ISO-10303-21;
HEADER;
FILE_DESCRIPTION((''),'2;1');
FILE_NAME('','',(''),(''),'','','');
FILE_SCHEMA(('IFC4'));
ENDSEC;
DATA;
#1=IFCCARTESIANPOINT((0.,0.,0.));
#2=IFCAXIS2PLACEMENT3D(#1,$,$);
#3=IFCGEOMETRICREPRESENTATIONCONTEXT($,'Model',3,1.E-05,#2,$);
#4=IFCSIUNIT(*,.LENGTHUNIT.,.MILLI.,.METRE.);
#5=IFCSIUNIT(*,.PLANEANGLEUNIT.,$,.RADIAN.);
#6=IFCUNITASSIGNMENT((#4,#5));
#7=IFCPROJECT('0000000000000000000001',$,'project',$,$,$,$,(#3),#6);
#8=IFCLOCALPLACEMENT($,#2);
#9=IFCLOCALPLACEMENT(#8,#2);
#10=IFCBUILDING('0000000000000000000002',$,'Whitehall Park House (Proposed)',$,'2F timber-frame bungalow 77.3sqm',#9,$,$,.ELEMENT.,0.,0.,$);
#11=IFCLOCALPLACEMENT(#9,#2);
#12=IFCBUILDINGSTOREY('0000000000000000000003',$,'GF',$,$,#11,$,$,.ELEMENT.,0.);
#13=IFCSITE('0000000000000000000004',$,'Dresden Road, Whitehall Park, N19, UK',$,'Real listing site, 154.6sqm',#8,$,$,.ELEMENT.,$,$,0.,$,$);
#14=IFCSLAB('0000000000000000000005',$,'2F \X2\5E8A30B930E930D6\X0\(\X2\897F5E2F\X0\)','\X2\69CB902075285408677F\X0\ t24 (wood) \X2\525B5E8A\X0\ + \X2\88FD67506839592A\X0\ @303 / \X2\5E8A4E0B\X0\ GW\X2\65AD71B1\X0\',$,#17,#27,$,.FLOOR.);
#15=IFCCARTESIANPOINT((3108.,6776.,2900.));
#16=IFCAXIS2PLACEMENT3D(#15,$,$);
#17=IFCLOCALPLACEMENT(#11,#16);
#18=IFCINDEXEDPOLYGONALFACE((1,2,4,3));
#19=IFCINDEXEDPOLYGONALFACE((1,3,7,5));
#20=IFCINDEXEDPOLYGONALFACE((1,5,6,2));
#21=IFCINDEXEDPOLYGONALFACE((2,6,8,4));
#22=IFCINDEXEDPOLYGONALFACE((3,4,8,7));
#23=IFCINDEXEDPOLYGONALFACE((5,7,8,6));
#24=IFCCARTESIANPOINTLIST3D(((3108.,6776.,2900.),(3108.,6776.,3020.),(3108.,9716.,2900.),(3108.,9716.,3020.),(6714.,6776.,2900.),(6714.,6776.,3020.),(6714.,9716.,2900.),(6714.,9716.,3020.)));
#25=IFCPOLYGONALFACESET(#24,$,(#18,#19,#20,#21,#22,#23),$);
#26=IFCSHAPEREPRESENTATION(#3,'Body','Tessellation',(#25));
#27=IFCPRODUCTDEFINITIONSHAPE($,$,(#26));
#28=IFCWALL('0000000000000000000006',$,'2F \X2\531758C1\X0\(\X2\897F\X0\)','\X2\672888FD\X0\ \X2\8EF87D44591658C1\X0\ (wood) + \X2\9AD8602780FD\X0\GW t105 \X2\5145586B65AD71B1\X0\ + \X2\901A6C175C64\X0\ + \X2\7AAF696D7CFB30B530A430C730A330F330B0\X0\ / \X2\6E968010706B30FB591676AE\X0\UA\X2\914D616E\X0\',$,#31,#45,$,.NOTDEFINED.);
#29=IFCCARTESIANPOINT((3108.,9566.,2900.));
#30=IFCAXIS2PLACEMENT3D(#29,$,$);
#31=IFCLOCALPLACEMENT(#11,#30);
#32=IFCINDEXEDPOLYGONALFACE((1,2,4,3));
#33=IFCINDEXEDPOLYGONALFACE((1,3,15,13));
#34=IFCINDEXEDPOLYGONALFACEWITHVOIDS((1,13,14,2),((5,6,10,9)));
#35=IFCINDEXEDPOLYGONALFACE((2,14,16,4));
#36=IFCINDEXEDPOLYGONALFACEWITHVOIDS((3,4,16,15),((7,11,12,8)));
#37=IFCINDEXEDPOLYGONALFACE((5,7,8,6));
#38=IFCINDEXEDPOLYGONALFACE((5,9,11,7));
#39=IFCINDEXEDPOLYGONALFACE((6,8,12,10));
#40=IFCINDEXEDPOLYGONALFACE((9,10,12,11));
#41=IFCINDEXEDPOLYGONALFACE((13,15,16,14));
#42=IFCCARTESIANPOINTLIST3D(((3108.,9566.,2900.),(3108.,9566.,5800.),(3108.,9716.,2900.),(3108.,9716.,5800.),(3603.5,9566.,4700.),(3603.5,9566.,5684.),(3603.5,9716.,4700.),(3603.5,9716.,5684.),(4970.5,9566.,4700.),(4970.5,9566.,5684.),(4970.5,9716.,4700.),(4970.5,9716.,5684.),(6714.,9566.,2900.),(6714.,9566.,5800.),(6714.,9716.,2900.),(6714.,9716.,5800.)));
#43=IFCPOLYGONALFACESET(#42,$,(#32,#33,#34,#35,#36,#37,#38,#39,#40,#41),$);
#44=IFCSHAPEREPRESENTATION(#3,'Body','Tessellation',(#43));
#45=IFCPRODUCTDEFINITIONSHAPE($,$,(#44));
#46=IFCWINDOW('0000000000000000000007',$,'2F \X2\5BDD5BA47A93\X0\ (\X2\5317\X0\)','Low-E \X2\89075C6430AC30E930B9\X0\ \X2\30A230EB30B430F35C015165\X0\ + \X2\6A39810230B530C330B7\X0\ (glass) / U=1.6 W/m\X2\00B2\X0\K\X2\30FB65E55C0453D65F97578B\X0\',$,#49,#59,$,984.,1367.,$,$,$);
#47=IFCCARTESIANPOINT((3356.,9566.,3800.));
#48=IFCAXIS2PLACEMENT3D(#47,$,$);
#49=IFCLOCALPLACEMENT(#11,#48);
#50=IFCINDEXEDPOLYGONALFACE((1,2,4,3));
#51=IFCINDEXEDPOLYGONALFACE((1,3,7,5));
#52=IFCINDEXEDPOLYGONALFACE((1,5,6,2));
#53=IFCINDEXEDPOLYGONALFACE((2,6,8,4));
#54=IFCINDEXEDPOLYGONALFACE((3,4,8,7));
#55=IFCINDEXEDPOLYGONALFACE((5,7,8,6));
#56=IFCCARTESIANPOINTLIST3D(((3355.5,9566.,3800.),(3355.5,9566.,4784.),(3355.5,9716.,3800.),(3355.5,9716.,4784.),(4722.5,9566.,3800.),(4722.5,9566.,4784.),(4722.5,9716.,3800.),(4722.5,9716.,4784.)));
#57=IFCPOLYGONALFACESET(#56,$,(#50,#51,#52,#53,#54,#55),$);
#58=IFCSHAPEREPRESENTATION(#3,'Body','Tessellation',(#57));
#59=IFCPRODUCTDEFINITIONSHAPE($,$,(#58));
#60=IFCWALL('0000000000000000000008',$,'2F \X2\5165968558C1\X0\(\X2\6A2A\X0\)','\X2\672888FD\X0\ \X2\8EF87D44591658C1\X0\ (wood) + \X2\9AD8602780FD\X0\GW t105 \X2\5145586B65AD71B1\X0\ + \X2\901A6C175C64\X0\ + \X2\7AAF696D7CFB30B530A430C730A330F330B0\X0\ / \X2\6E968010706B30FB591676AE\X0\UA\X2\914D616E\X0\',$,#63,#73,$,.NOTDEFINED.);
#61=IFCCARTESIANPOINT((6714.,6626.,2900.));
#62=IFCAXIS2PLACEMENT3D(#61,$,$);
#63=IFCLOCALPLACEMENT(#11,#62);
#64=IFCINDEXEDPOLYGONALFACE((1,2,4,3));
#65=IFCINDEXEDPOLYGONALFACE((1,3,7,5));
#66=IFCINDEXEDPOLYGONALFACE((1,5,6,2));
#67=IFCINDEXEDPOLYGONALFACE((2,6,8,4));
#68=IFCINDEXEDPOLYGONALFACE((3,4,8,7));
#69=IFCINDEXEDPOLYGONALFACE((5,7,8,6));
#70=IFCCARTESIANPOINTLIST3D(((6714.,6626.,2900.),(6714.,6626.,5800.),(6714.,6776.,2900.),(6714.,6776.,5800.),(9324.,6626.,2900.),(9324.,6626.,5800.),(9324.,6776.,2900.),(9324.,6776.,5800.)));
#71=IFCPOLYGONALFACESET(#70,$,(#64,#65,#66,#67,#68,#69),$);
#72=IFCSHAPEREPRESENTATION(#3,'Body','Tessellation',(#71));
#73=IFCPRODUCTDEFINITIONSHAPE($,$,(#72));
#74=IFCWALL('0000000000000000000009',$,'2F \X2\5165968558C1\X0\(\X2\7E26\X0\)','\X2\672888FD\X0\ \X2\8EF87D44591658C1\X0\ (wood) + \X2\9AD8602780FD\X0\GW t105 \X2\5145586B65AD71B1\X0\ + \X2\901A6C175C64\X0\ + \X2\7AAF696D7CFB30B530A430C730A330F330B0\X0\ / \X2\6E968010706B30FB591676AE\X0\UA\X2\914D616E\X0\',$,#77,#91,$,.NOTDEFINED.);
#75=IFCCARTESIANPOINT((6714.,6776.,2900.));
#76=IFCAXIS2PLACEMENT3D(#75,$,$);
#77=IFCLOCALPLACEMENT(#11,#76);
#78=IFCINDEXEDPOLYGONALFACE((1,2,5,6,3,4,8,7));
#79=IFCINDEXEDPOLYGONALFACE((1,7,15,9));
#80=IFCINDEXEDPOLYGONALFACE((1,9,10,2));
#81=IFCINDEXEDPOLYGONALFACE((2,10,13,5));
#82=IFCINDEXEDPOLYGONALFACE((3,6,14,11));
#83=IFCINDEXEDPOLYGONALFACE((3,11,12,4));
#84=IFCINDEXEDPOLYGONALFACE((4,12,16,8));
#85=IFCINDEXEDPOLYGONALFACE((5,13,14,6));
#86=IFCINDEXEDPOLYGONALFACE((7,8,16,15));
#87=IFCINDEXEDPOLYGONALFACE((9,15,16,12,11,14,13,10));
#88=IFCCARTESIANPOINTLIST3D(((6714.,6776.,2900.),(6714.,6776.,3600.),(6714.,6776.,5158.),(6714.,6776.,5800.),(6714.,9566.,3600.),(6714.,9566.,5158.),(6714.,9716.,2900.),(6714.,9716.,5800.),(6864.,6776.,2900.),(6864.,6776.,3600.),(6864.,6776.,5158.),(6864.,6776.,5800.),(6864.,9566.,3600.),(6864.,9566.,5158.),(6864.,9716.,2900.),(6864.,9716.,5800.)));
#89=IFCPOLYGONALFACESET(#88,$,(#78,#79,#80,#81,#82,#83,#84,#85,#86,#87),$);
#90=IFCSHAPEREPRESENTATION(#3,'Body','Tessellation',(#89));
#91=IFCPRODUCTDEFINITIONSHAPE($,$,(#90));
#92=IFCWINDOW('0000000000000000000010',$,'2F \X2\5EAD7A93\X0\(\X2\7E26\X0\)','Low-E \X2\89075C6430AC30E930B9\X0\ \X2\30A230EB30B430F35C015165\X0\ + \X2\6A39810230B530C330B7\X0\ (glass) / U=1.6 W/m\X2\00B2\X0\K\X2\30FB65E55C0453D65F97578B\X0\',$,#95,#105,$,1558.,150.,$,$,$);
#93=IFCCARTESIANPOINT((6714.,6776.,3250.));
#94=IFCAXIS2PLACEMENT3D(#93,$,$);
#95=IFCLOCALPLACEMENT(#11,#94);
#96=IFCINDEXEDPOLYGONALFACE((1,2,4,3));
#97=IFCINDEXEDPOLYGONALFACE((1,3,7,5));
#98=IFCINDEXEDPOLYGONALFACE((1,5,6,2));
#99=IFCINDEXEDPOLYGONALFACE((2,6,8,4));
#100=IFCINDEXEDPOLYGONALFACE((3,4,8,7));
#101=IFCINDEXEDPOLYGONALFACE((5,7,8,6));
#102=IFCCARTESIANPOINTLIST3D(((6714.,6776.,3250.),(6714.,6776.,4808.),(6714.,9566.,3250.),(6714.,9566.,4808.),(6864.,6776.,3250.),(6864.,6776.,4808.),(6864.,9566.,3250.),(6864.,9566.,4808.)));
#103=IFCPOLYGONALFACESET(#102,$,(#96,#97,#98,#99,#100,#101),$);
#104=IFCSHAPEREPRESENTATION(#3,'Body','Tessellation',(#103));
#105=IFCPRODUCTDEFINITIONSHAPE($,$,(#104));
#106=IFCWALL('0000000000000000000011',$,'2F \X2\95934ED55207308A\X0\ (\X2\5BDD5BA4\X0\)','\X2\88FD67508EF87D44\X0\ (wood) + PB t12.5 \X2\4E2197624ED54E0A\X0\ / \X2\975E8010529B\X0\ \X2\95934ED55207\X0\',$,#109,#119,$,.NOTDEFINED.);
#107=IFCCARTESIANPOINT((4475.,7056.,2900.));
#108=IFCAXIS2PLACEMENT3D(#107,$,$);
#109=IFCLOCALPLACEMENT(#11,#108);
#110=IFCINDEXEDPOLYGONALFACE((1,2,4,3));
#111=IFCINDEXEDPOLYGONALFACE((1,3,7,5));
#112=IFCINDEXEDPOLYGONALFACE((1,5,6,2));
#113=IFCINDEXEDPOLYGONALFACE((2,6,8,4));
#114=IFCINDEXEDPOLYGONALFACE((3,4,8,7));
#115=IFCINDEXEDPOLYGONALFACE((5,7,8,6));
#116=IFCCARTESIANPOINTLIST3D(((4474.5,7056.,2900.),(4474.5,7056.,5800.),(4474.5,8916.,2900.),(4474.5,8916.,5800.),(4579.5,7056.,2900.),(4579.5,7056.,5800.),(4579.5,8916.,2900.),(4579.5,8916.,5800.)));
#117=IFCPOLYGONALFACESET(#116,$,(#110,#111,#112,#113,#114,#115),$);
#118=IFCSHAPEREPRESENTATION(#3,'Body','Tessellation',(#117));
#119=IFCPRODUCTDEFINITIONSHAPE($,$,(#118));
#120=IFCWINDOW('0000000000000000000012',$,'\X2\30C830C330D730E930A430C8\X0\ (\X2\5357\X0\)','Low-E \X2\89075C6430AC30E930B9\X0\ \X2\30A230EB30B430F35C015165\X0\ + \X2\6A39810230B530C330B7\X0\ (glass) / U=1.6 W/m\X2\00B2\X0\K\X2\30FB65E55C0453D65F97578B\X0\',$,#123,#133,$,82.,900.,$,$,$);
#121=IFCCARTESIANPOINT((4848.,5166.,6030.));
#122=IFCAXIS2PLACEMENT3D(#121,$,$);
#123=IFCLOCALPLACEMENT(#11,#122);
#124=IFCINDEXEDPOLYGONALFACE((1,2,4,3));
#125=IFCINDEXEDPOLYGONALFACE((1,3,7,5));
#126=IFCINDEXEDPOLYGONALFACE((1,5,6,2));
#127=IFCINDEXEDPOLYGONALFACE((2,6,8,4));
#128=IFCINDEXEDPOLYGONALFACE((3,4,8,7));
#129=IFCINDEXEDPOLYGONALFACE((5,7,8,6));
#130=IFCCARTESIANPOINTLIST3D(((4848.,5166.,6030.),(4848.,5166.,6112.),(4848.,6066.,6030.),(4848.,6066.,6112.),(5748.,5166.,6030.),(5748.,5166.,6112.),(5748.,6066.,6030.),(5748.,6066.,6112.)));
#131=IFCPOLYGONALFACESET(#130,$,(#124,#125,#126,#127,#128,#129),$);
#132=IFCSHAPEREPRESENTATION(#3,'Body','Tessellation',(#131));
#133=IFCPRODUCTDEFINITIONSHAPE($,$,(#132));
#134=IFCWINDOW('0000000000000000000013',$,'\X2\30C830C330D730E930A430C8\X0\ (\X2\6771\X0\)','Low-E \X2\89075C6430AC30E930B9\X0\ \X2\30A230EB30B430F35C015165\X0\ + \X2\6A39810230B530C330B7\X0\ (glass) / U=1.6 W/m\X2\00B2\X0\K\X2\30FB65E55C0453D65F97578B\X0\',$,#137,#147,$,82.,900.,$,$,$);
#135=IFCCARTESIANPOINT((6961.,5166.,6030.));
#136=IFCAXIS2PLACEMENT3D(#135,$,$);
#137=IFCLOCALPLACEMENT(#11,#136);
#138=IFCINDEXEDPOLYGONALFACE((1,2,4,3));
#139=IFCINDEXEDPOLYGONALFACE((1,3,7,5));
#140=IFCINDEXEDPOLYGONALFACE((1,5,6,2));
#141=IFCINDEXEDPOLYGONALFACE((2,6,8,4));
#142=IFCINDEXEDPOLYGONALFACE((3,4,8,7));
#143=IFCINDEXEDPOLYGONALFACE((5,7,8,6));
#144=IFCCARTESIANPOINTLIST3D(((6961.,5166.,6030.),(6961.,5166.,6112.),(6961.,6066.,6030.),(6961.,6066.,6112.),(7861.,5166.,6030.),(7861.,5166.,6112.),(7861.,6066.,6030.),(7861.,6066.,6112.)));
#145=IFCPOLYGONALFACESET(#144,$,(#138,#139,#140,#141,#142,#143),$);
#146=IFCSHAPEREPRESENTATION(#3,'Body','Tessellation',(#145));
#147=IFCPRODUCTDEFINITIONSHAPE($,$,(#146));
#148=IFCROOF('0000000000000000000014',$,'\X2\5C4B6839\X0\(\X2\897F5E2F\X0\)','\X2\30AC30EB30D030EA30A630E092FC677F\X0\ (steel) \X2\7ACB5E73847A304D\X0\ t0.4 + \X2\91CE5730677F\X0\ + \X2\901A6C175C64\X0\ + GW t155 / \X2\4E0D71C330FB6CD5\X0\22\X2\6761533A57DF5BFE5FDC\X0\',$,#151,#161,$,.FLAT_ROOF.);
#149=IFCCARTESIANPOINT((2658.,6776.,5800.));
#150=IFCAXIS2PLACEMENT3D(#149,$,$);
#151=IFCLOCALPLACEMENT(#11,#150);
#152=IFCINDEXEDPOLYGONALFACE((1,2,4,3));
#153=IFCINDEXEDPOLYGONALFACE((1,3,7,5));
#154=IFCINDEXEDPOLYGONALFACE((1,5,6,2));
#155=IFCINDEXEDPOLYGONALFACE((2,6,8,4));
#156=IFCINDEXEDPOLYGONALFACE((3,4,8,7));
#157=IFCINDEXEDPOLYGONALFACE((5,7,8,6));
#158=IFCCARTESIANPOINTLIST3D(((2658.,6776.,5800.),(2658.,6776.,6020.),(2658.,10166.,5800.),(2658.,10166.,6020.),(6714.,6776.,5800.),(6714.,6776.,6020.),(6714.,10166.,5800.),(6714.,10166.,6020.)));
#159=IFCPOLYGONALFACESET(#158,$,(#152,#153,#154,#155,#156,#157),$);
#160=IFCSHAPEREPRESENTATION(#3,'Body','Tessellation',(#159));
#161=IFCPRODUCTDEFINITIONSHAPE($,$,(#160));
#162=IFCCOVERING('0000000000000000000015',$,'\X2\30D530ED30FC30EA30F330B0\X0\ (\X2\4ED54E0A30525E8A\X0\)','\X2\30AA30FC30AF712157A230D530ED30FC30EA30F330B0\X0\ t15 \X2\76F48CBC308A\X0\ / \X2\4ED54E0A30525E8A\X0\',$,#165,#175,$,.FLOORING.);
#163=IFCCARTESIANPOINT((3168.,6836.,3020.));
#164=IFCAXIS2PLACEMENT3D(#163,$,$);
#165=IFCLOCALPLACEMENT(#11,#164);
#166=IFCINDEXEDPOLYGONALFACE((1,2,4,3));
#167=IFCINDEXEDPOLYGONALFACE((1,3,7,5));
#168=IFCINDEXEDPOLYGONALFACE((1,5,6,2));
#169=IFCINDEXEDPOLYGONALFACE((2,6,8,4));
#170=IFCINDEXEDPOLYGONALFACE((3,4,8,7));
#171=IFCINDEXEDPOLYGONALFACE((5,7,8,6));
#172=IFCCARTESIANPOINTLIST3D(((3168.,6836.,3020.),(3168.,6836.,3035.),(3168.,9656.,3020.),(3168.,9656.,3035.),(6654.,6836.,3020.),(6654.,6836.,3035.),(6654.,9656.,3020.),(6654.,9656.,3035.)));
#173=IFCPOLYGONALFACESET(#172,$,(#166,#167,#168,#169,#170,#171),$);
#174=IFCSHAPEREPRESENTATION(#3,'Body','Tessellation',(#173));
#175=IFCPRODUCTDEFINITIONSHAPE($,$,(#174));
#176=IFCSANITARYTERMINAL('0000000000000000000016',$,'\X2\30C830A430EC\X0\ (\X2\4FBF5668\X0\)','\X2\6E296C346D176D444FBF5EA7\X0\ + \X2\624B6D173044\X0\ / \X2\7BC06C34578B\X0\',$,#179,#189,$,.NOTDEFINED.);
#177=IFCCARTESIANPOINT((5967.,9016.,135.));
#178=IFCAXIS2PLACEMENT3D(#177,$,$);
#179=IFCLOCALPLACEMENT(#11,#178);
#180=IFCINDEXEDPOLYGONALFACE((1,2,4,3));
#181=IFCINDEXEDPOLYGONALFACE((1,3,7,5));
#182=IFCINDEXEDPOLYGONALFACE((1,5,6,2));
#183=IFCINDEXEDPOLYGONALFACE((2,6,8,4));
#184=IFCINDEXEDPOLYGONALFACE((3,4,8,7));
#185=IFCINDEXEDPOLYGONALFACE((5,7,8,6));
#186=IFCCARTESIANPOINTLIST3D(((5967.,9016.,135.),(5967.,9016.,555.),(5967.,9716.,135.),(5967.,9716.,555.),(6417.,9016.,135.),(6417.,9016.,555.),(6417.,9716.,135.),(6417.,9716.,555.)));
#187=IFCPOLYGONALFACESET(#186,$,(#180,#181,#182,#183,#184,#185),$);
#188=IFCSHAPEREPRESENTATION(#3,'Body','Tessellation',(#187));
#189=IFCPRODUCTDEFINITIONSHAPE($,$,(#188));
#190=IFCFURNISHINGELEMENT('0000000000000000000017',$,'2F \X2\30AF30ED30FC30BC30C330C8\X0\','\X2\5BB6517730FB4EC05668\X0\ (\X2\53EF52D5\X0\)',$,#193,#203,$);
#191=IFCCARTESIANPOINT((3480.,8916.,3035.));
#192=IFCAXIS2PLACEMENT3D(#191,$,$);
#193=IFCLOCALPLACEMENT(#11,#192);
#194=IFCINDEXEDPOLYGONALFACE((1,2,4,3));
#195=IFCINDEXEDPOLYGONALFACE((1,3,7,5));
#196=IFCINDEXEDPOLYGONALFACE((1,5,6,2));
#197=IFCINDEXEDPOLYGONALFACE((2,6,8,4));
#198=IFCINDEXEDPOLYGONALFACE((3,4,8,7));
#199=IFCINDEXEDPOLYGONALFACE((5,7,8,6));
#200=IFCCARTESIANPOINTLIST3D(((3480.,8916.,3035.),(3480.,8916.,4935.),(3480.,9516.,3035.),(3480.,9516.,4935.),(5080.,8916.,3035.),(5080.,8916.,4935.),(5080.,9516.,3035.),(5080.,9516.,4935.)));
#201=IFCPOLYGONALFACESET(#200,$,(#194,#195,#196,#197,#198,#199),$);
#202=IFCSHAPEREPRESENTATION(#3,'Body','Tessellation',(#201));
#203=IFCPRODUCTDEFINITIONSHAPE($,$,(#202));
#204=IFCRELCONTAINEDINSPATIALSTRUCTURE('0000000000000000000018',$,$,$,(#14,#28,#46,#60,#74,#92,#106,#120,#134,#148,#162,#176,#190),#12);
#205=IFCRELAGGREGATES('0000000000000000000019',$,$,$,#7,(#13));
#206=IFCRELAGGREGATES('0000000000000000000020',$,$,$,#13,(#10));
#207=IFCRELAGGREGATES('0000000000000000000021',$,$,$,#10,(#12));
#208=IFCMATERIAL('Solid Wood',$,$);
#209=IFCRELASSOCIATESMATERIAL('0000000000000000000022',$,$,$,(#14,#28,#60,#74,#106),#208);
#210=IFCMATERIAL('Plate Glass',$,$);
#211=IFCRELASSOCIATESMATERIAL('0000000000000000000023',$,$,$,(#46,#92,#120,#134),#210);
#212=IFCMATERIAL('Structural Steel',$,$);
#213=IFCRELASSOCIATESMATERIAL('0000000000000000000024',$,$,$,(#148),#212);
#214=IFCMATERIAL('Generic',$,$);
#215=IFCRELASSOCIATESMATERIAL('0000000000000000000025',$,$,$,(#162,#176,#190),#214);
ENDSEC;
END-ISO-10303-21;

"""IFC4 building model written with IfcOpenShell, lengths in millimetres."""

from ifc_helpers import new_model, si_unit, frame, frame_2d, origin, place, context, project, spatial, rectangle, extrude, material, element, fill, save


model = new_model("IFC4")

# Units and contexts
model_context = context("Model", 3, precision=1e-05, world=origin())
ifc_project = project(units=[si_unit("LENGTHUNIT", "METRE", prefix="MILLI"), si_unit("PLANEANGLEUNIT", "RADIAN")], contexts=[model_context])

# Site, building, storey
site_placement = place(None, origin())
site = spatial("IfcSite", under=ifc_project, at=site_placement, Name="Dresden Road, Whitehall Park, N19, UK", ObjectType="Real listing site, 154.6sqm", CompositionType="ELEMENT", RefElevation=0.0)
building_placement = place(site_placement, origin())
building = spatial("IfcBuilding", under=site, at=building_placement, Name="Whitehall Park House (Proposed)", ObjectType="2F timber-frame bungalow 77.3sqm", CompositionType="ELEMENT", ElevationOfRefHeight=0.0, ElevationOfTerrain=0.0)
storey_placement = place(building_placement, origin())
storey = spatial("IfcBuildingStorey", under=building, at=storey_placement, Name="GF", CompositionType="ELEMENT", Elevation=0.0)

# Slab
ifc_material_1 = material(Name="Solid Wood")
slab_placement = place(storey_placement, frame((3108.0, 6776.0, 2900.0)))
element("IfcSlab", 1, at=slab_placement, inside=storey, material=ifc_material_1, Name="2F 床スラブ(西帯)", Description="構造用合板 t24 (wood) 剛床 + 製材根太 @303 / 床下 GW断熱", PredefinedType="FLOOR", context=model_context, shape_type="SweptSolid", body=[
    extrude(rectangle(XDim=3606.0, YDim=2940.0, at=frame_2d((1803.0, 1470.0))), frame((3108.0, 6776.0, 2900.0)), (0.0, 0.0, 1.0), 120.0),
])

# Wall, opening, window
wall_1_placement = place(storey_placement, frame((3108.0, 9566.0, 2900.0)))
wall_1 = element("IfcWall", 2, at=wall_1_placement, inside=storey, material=ifc_material_1, Name="2F 北壁(西)", Description="木製 軸組外壁 (wood) + 高性能GW t105 充填断熱 + 通気層 + 窯業系サイディング / 準耐火・外皮UA配慮", PredefinedType="NOTDEFINED", context=model_context, shape_type="SweptSolid", body=[
    extrude(rectangle(XDim=3606.0, YDim=150.0, at=frame_2d((1803.0, 75.0))), frame((3108.0, 9566.0, 2900.0)), (0.0, 0.0, 1.0), 2900.0),
])
opening_1_placement = place(storey_placement, frame((3356.0, 9566.0, 3800.0)))
opening_1 = element("IfcOpeningElement", 3, at=opening_1_placement, cuts=wall_1, PredefinedType="NOTDEFINED", context=model_context, shape_type="SweptSolid", body=[
    extrude(rectangle(XDim=1367.0, YDim=150.0, at=frame_2d((683.0, 75.0))), frame((3356.0, 9566.0, 3800.0)), (0.0, 0.0, 1.0), 984.0),
])
ifc_material_2 = material(Name="Plate Glass")
window_1_placement = place(storey_placement, frame((3356.0, 9566.0, 3800.0)))
window_1 = element("IfcWindow", 4, at=window_1_placement, inside=storey, material=ifc_material_2, Name="2F 寝室窓 (北)", Description="Low-E 複層ガラス アルゴン封入 + 樹脂サッシ (glass) / U=1.6 W/m²K・日射取得型", OverallHeight=984.0, OverallWidth=1367.0, context=model_context, shape_type="SweptSolid", body=[
    extrude(rectangle(XDim=1367.0, YDim=150.0, at=frame_2d((683.0, 75.0))), frame((3356.0, 9566.0, 3800.0)), (0.0, 0.0, 1.0), 984.0),
])
fill(opening_1, window_1)

# Wall
wall_2_placement = place(storey_placement, frame((6714.0, 6626.0, 2900.0)))
element("IfcWall", 5, at=wall_2_placement, inside=storey, material=ifc_material_1, Name="2F 入隅壁(横)", Description="木製 軸組外壁 (wood) + 高性能GW t105 充填断熱 + 通気層 + 窯業系サイディング / 準耐火・外皮UA配慮", PredefinedType="NOTDEFINED", context=model_context, shape_type="SweptSolid", body=[
    extrude(rectangle(XDim=2610.0, YDim=150.0, at=frame_2d((1305.0, 75.0))), frame((6714.0, 6626.0, 2900.0)), (0.0, 0.0, 1.0), 2900.0),
])

# Wall, opening, window
wall_3_placement = place(storey_placement, frame((6714.0, 6776.0, 2900.0)))
wall_3 = element("IfcWall", 6, at=wall_3_placement, inside=storey, material=ifc_material_1, Name="2F 入隅壁(縦)", Description="木製 軸組外壁 (wood) + 高性能GW t105 充填断熱 + 通気層 + 窯業系サイディング / 準耐火・外皮UA配慮", PredefinedType="NOTDEFINED", context=model_context, shape_type="SweptSolid", body=[
    extrude(rectangle(XDim=150.0, YDim=2940.0, at=frame_2d((75.0, 1470.0))), frame((6714.0, 6776.0, 2900.0)), (0.0, 0.0, 1.0), 2900.0),
])
opening_2_placement = place(storey_placement, frame((6714.0, 6776.0, 3250.0)))
opening_2 = element("IfcOpeningElement", 7, at=opening_2_placement, cuts=wall_3, PredefinedType="NOTDEFINED", context=model_context, shape_type="SweptSolid", body=[
    extrude(rectangle(XDim=150.0, YDim=2790.0, at=frame_2d((75.0, 1395.0))), frame((6714.0, 6776.0, 3250.0)), (0.0, 0.0, 1.0), 1558.0),
])
window_2_placement = place(storey_placement, frame((6714.0, 6776.0, 3250.0)))
window_2 = element("IfcWindow", 8, at=window_2_placement, inside=storey, material=ifc_material_2, Name="2F 庭窓(縦)", Description="Low-E 複層ガラス アルゴン封入 + 樹脂サッシ (glass) / U=1.6 W/m²K・日射取得型", OverallHeight=1558.0, OverallWidth=150.0, context=model_context, shape_type="SweptSolid", body=[
    extrude(rectangle(XDim=150.0, YDim=2790.0, at=frame_2d((75.0, 1395.0))), frame((6714.0, 6776.0, 3250.0)), (0.0, 0.0, 1.0), 1558.0),
])
fill(opening_2, window_2)

# Wall
wall_4_placement = place(storey_placement, frame((4475.0, 7056.0, 2900.0)))
element("IfcWall", 9, at=wall_4_placement, inside=storey, material=ifc_material_1, Name="2F 間仕切り (寝室)", Description="製材軸組 (wood) + PB t12.5 両面仕上 / 非耐力 間仕切", PredefinedType="NOTDEFINED", context=model_context, shape_type="SweptSolid", body=[
    extrude(rectangle(XDim=105.0, YDim=1860.0, at=frame_2d((52.0, 930.0))), frame((4475.0, 7056.0, 2900.0)), (0.0, 0.0, 1.0), 2900.0),
])

# Windows
window_3_placement = place(storey_placement, frame((4848.0, 5166.0, 6030.0)))
element("IfcWindow", 10, at=window_3_placement, inside=storey, material=ifc_material_2, Name="トップライト (南)", Description="Low-E 複層ガラス アルゴン封入 + 樹脂サッシ (glass) / U=1.6 W/m²K・日射取得型", OverallHeight=82.0, OverallWidth=900.0, context=model_context, shape_type="SweptSolid", body=[
    extrude(rectangle(XDim=900.0, YDim=900.0, at=frame_2d((450.0, 450.0))), frame((4848.0, 5166.0, 6030.0)), (0.0, 0.0, 1.0), 82.0),
])
window_4_placement = place(storey_placement, frame((6961.0, 5166.0, 6030.0)))
element("IfcWindow", 11, at=window_4_placement, inside=storey, material=ifc_material_2, Name="トップライト (東)", Description="Low-E 複層ガラス アルゴン封入 + 樹脂サッシ (glass) / U=1.6 W/m²K・日射取得型", OverallHeight=82.0, OverallWidth=900.0, context=model_context, shape_type="SweptSolid", body=[
    extrude(rectangle(XDim=900.0, YDim=900.0, at=frame_2d((450.0, 450.0))), frame((6961.0, 5166.0, 6030.0)), (0.0, 0.0, 1.0), 82.0),
])

# Roof
ifc_material_3 = material(Name="Structural Steel")
for number, where, name in (
    (12, (2658.0, 6776.0, 5800.0), "屋根(西帯)"),
):
    element("IfcRoof", number, at=place(storey_placement, frame(where)), inside=storey, material=ifc_material_3, Name=name, Description="ガルバリウム鋼板 (steel) 立平葺き t0.4 + 野地板 + 通気層 + GW t155 / 不燃・法22条区域対応", PredefinedType="FLAT_ROOF", context=model_context, shape_type="SweptSolid", body=[
        extrude(rectangle(XDim=4056.0, YDim=3390.0, at=frame_2d((2028.0, 1695.0))), frame((2658.0, 6776.0, 5800.0)), (0.0, 0.0, 1.0), 220.0),
    ])

# Covering
ifc_material_4 = material(Name="Generic")
covering_placement = place(storey_placement, frame((3168.0, 6836.0, 3020.0)))
element("IfcCovering", 13, at=covering_placement, inside=storey, material=ifc_material_4, Name="フローリング (仕上げ床)", Description="オーク無垢フローリング t15 直貼り / 仕上げ床", PredefinedType="FLOORING", context=model_context, shape_type="SweptSolid", body=[
    extrude(rectangle(XDim=3486.0, YDim=2820.0, at=frame_2d((1743.0, 1410.0))), frame((3168.0, 6836.0, 3020.0)), (0.0, 0.0, 1.0), 15.0),
])

# Sanitary terminal
sanitary_terminal_placement = place(storey_placement, frame((5967.0, 9016.0, 135.0)))
element("IfcSanitaryTerminal", 14, at=sanitary_terminal_placement, inside=storey, material=ifc_material_4, Name="トイレ (便器)", Description="温水洗浄便座 + 手洗い / 節水型", PredefinedType="NOTDEFINED", context=model_context, shape_type="SweptSolid", body=[
    extrude(rectangle(XDim=450.0, YDim=700.0, at=frame_2d((225.0, 350.0))), frame((5967.0, 9016.0, 135.0)), (0.0, 0.0, 1.0), 420.0),
])

# Furnishing element
furnishing_1_placement = place(storey_placement, frame((3480.0, 8916.0, 3035.0)))
element("IfcFurnishingElement", 15, at=furnishing_1_placement, inside=storey, material=ifc_material_4, Name="2F クローゼット", Description="家具・什器 (可動)", context=model_context, shape_type="SweptSolid", body=[
    extrude(rectangle(XDim=1600.0, YDim=600.0, at=frame_2d((800.0, 300.0))), frame((3480.0, 8916.0, 3035.0)), (0.0, 0.0, 1.0), 1900.0),
])

save(model, "model.ifc")
